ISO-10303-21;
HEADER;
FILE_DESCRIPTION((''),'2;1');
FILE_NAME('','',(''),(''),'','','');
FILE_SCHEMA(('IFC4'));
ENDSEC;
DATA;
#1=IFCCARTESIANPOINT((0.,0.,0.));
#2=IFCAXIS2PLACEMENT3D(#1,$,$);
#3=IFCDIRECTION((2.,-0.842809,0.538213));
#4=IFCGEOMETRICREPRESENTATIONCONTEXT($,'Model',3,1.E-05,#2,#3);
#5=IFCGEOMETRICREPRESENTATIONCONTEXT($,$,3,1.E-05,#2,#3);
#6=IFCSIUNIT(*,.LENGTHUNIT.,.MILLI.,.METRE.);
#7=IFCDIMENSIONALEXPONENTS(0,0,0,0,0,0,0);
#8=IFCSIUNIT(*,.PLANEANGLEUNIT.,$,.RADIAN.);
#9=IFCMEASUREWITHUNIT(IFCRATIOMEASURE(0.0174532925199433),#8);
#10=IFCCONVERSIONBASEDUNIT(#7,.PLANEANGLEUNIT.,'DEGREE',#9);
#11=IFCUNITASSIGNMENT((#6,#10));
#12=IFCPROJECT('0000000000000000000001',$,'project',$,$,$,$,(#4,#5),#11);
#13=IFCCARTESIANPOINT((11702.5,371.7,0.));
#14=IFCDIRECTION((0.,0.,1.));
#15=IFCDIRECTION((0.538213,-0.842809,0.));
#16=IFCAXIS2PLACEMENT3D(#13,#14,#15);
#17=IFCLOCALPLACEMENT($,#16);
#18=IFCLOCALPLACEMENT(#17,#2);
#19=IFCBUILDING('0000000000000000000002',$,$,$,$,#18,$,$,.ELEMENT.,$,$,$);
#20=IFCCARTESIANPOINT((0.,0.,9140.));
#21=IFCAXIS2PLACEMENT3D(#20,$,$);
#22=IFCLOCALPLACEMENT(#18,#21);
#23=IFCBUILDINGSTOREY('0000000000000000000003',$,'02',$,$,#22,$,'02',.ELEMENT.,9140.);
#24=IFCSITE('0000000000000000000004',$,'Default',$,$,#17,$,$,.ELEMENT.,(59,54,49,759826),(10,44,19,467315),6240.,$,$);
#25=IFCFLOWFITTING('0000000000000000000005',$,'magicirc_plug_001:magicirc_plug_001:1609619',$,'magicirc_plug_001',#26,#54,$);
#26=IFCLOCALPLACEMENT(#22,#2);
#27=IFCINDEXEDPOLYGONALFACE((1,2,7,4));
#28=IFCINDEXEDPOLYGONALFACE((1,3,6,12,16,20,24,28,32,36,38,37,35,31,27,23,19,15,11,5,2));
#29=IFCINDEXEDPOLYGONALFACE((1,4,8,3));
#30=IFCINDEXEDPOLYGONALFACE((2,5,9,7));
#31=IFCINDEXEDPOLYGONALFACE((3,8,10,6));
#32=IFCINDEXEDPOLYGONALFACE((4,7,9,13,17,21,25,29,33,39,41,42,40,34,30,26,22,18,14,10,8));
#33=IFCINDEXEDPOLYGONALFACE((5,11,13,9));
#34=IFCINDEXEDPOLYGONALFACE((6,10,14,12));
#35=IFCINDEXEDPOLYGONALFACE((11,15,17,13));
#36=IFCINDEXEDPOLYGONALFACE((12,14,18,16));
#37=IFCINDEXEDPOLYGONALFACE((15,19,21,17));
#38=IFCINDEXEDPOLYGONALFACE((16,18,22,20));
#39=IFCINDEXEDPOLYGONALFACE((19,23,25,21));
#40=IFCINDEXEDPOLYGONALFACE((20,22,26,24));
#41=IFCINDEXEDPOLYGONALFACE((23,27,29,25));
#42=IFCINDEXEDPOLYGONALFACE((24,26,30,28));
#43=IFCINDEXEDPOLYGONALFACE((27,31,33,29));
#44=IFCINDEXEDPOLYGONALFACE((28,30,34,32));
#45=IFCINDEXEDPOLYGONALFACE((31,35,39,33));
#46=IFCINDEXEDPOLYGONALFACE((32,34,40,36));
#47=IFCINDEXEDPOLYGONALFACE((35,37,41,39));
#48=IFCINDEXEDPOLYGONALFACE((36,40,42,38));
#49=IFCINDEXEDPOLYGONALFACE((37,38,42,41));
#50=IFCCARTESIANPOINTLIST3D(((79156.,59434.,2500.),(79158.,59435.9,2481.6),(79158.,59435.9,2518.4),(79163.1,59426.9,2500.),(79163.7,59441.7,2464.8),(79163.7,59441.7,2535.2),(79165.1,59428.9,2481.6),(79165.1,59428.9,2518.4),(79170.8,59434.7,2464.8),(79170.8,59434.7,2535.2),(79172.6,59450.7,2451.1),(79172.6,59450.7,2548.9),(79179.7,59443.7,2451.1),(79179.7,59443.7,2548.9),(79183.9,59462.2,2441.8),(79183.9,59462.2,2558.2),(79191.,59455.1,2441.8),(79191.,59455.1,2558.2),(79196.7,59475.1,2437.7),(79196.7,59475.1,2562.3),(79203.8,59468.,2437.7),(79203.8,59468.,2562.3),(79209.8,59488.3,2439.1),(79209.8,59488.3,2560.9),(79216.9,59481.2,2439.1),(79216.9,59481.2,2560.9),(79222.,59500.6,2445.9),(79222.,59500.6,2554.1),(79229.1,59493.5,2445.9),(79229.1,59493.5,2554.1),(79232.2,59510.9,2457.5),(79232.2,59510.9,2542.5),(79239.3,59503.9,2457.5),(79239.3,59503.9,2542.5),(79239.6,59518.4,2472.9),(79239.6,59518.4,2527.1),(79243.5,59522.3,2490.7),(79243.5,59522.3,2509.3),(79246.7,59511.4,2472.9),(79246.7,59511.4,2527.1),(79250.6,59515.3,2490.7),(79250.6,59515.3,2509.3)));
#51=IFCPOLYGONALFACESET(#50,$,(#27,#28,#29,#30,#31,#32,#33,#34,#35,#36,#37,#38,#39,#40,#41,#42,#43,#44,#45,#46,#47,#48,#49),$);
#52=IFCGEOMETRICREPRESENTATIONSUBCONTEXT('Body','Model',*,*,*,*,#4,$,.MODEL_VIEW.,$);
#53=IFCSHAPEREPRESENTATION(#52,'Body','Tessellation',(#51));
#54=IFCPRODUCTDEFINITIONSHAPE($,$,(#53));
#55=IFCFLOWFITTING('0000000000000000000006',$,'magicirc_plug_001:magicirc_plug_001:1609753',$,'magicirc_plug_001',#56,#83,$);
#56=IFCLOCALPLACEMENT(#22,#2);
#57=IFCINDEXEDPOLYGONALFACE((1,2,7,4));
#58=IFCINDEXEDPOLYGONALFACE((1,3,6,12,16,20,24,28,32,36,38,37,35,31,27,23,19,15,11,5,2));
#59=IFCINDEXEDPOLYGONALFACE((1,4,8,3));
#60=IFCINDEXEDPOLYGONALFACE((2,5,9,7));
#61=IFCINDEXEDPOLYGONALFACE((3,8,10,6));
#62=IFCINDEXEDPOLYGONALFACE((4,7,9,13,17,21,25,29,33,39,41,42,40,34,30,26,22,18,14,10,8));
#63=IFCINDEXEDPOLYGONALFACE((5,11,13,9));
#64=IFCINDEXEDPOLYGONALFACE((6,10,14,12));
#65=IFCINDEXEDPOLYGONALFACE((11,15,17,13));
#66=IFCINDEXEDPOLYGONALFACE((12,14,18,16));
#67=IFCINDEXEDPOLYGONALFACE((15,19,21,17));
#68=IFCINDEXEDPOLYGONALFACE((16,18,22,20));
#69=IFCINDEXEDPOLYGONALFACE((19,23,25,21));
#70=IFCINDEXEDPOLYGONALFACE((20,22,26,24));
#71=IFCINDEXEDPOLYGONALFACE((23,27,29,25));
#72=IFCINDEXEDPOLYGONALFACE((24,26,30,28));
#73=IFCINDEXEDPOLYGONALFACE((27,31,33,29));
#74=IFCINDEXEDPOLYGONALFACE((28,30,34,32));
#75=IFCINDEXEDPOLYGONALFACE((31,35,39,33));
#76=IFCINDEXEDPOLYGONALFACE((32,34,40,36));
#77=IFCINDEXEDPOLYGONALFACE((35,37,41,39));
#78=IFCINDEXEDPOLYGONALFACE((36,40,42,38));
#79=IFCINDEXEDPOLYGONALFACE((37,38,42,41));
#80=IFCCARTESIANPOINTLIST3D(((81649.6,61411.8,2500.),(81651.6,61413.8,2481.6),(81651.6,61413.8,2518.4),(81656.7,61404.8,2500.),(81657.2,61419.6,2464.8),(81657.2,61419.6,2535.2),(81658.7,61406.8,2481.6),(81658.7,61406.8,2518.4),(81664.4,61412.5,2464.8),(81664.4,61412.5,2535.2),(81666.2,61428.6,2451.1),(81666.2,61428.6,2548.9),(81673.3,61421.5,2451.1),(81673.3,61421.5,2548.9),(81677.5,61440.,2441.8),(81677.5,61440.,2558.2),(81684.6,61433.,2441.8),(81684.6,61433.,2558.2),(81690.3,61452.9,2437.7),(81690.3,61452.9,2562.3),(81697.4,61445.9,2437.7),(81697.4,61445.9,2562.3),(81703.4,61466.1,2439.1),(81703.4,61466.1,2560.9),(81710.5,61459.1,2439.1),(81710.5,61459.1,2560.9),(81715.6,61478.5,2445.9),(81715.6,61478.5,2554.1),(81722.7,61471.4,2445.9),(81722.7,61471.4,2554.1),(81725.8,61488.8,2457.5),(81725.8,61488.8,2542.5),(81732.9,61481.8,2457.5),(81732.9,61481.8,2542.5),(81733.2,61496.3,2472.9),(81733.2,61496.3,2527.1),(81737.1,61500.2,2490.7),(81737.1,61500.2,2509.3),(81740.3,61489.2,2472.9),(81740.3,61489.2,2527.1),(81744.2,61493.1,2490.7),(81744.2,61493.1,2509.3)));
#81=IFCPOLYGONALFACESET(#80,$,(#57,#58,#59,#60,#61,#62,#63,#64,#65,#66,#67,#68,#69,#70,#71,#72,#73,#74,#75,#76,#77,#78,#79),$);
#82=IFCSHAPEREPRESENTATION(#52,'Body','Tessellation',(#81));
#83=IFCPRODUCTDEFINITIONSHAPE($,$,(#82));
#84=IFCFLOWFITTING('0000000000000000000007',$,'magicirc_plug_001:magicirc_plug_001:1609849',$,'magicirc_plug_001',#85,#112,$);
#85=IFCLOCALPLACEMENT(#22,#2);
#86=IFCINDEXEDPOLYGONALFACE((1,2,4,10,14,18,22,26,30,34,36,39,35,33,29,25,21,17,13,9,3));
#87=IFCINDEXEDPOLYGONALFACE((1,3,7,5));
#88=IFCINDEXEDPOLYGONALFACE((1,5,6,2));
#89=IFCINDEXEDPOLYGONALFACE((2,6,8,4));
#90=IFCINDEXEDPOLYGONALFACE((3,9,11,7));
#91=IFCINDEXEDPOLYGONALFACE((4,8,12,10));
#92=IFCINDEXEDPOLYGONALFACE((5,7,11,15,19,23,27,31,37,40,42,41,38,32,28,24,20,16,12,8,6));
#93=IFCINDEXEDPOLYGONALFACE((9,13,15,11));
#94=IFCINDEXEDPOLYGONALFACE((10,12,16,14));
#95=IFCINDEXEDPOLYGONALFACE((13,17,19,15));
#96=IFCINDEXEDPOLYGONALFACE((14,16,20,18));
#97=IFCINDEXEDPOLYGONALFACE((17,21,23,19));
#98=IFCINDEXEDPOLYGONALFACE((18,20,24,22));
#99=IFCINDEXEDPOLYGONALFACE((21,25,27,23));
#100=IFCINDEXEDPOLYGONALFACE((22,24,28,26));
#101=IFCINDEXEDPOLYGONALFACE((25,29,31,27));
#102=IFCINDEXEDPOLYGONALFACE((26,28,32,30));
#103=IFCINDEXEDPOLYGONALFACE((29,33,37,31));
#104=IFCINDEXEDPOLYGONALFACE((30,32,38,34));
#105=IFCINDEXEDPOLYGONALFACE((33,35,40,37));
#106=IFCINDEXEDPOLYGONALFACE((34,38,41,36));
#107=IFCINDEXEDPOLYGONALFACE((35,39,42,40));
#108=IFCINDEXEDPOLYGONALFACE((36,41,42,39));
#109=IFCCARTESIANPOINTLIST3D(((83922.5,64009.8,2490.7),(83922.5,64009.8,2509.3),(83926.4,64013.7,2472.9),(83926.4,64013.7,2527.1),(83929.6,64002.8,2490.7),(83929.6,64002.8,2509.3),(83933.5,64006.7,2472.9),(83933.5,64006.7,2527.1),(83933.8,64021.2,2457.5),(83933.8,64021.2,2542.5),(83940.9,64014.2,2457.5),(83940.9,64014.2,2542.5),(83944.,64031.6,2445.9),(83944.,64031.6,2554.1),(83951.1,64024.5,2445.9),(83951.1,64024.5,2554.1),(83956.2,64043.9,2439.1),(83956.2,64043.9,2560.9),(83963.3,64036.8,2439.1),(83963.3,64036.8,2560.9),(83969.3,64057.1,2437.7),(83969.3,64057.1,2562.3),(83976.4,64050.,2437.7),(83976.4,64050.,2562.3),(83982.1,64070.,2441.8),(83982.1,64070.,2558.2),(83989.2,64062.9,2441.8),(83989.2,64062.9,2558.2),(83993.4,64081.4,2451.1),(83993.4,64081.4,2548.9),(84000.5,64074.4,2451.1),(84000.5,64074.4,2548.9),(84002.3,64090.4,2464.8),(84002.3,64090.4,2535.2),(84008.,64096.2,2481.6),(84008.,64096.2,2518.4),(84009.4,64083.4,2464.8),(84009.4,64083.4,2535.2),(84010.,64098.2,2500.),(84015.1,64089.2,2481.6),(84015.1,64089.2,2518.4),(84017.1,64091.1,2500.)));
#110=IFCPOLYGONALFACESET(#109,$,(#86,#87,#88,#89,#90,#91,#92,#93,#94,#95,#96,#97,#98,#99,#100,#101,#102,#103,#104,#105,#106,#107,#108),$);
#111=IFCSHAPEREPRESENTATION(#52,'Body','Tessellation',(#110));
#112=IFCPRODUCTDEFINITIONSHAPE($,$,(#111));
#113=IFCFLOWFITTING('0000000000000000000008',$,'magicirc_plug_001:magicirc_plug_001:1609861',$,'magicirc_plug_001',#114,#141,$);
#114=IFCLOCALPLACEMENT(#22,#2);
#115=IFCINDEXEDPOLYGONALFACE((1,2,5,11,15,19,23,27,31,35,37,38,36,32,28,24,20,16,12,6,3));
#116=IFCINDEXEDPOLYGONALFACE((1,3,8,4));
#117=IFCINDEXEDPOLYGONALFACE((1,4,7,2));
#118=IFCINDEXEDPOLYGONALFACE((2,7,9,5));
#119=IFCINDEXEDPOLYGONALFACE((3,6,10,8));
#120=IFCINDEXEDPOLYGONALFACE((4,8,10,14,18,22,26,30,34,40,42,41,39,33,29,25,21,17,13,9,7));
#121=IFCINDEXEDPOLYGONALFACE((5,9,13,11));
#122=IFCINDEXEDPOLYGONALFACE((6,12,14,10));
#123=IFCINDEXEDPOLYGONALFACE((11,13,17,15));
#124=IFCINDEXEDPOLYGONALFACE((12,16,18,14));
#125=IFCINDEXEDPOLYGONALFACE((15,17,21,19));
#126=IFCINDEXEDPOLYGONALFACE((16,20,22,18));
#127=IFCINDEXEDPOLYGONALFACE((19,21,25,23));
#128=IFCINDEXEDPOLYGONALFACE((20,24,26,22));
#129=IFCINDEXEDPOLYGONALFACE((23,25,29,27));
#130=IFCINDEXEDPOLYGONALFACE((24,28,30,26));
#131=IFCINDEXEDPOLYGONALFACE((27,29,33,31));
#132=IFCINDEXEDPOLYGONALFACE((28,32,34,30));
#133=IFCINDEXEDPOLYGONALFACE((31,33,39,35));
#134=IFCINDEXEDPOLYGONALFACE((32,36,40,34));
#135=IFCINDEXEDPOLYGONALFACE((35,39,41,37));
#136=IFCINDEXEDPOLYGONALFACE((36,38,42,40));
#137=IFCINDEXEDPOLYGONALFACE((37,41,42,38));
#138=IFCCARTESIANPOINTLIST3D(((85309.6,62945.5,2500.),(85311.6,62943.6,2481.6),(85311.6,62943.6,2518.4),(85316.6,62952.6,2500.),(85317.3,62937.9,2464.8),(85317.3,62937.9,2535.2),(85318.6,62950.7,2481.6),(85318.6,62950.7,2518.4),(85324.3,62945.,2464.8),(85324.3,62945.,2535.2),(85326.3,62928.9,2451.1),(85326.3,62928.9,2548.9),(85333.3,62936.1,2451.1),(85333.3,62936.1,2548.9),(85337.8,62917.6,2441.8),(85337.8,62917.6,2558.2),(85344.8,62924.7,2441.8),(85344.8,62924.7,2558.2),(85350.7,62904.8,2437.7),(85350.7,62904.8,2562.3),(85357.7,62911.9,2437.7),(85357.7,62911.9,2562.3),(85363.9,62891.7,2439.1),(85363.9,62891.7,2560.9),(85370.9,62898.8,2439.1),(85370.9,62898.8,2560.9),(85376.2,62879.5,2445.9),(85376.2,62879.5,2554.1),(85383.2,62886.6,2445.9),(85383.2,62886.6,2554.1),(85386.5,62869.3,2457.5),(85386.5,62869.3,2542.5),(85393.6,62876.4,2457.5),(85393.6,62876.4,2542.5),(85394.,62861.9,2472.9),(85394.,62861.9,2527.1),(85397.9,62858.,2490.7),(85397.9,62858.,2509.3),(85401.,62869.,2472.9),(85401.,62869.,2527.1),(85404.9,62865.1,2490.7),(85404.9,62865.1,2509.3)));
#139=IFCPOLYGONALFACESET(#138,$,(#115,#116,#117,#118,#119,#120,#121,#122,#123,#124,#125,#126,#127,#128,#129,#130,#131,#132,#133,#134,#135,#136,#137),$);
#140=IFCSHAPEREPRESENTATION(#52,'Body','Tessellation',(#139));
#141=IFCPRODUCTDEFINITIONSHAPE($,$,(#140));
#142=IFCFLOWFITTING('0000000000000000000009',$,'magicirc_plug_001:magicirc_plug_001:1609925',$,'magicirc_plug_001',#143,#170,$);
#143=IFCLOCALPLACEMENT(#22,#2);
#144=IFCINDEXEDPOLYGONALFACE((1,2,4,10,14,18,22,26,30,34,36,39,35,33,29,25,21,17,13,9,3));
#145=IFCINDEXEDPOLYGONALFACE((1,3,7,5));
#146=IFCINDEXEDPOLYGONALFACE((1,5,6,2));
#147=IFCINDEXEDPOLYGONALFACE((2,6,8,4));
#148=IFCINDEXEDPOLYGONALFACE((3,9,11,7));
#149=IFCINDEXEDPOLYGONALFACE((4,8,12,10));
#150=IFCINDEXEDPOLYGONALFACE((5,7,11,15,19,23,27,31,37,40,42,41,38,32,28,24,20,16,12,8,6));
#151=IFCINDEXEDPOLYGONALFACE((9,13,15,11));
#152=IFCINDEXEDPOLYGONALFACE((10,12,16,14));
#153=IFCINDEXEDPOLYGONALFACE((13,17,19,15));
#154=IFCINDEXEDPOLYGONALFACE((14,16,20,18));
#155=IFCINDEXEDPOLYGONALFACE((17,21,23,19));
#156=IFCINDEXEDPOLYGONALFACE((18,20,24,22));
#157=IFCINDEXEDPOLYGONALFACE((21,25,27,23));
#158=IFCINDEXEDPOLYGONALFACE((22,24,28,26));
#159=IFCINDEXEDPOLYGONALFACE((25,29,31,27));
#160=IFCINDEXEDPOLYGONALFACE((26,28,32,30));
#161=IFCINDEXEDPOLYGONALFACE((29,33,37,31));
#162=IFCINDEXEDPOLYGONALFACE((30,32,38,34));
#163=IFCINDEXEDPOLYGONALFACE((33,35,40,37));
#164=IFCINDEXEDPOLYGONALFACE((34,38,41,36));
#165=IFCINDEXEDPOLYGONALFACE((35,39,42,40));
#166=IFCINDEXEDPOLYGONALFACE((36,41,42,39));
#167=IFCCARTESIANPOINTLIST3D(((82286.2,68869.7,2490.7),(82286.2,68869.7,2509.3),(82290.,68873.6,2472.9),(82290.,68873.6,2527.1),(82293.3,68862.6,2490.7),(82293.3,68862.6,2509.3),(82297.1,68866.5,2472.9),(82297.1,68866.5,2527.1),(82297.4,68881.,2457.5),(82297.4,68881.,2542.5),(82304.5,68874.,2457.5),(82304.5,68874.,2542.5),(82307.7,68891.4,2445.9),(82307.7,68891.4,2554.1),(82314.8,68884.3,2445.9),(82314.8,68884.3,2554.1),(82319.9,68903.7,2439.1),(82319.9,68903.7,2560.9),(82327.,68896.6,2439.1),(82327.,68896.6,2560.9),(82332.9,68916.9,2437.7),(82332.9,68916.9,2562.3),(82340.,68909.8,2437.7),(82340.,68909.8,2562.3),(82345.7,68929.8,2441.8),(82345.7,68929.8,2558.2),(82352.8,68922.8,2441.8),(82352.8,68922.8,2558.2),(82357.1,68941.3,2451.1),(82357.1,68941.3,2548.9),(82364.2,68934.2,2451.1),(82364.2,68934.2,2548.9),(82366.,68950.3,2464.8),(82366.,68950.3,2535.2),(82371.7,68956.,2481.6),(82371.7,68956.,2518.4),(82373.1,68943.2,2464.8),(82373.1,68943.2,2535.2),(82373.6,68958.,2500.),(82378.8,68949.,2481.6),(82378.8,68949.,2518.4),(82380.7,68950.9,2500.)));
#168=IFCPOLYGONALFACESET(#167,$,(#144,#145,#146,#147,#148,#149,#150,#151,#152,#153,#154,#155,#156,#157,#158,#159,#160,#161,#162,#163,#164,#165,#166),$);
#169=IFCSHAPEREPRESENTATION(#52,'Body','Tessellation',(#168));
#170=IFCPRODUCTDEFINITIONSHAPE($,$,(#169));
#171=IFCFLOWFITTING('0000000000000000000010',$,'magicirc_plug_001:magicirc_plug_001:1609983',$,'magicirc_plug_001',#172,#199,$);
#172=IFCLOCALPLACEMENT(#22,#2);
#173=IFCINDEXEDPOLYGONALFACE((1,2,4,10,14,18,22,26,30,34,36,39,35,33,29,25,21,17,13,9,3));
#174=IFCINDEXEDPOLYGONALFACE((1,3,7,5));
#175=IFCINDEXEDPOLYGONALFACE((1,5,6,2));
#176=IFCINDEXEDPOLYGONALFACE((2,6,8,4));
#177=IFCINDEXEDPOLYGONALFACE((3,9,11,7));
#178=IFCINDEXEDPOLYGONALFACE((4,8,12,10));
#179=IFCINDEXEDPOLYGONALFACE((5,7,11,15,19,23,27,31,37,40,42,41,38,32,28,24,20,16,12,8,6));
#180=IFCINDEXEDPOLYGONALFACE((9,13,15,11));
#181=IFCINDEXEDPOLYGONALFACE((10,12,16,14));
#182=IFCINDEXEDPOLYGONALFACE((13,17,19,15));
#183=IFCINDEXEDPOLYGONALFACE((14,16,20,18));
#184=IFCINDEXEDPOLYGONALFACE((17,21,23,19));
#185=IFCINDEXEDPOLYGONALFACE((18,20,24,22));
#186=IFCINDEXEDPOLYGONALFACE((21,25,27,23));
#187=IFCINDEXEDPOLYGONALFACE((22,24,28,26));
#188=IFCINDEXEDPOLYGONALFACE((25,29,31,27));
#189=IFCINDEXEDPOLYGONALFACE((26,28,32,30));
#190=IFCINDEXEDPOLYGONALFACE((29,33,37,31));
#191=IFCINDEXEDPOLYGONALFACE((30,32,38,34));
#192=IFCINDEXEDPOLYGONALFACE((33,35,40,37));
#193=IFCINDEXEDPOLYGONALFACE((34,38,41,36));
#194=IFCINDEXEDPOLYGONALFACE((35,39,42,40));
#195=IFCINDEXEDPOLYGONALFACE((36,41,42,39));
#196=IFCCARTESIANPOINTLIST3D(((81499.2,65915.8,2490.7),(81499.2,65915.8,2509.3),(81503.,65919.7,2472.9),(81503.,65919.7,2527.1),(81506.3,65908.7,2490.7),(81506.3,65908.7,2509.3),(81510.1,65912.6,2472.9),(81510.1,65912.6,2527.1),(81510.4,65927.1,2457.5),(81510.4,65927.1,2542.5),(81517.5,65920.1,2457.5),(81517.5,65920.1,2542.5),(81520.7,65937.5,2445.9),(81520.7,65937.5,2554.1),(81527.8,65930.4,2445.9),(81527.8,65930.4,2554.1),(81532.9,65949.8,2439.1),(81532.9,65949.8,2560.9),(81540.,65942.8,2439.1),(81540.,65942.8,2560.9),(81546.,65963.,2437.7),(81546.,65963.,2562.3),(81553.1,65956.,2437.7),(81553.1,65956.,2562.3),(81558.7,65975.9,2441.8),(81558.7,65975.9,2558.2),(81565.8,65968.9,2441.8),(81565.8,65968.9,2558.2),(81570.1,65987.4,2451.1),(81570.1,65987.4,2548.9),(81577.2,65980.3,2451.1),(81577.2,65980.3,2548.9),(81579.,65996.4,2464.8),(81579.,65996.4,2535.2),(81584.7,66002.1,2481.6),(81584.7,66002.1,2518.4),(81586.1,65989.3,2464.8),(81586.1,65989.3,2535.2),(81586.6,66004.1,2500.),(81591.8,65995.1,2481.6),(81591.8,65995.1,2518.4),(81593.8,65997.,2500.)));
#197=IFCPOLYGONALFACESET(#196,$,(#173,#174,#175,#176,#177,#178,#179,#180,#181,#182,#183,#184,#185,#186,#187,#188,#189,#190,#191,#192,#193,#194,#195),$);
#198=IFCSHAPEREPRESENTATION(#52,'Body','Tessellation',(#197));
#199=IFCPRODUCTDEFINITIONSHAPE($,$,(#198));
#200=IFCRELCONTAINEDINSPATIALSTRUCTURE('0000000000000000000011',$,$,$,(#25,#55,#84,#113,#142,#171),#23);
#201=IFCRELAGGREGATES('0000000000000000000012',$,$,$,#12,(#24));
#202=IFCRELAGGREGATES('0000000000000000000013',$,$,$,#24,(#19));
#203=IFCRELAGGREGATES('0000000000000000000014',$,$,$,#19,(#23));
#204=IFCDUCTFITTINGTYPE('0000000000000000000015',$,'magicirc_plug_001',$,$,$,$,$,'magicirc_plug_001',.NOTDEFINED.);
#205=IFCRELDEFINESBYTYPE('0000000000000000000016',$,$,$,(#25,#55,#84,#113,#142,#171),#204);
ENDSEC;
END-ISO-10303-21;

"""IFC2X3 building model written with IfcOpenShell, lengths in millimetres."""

from ifc_helpers import new_model, entity, si_unit, converted_unit, direction, frame, frame_2d, origin, place, context, subcontext, project, spatial, circle, extrude, source, transform, mapped, type_object, type_shapes, element, save


model = new_model("IFC2X3")

# Units and contexts
model_context = context("Model", 3, precision=1e-05, world=origin(), true_north=direction((2.0, -0.842809, 0.538213)))
context_of_model = context(None, 3, precision=1e-05, world=origin(), true_north=direction((2.0, -0.842809, 0.538213)))
body_context = subcontext(model_context, "Body", "Model", "MODEL_VIEW")
ifc_project = project(units=[si_unit("LENGTHUNIT", "METRE", prefix="MILLI"), converted_unit("PLANEANGLEUNIT", "DEGREE", entity("IfcRatioMeasure", 0.0174532925199433), si_unit("PLANEANGLEUNIT", "RADIAN"), dimensions=[0, 0, 0, 0, 0, 0, 0])], contexts=[model_context, context_of_model])

# Site, building, storey
site_placement = place(None, frame((11702.5, 371.7, 0.0), z_axis=(0.0, 0.0, 1.0), x_axis=(0.538213, -0.842809, 0.0)))
site = spatial("IfcSite", under=ifc_project, at=site_placement, Name="Default", CompositionType="ELEMENT", RefLatitude=(59, 54, 49, 759826), RefLongitude=(10, 44, 19, 467315), RefElevation=6240.0)
building_placement = place(site_placement, origin())
building = spatial("IfcBuilding", under=site, at=building_placement, CompositionType="ELEMENT")
storey_placement = place(building_placement, frame((0.0, 0.0, 9140.0)))
storey = spatial("IfcBuildingStorey", under=building, at=storey_placement, Name="02", LongName="02", CompositionType="ELEMENT", Elevation=9140.0)

# Flow fittings
duct_fitting_type_1 = type_object("IfcDuctFittingType", Name="magicirc_plug_001", ElementType="magicirc_plug_001", PredefinedType="NOTDEFINED")
shared_shape_1 = source(origin(), body_context, "Body", "SweptSolid", [
    extrude(circle(Radius=62.5, at=frame_2d((0.0, 0.0), x_axis=(1.0, 0.0))), frame((0.0, 0.0, 0.0), z_axis=(1.0, 0.0, 0.0), x_axis=(0.0, 1.0, 0.0)), (0.0, 0.0, 1.0), 10.0),
])
type_shapes(duct_fitting_type_1, [shared_shape_1])
for number, where, z_axis, x_axis, name in (
    (1, (79207.1, 59471.3, 2500.0), (0.0, 0.0, 1.0), (-0.710528, 0.703669, 0.0), "magicirc_plug_001:magicirc_plug_001:1609619"),
    (2, (81700.7, 61449.2, 2500.0), (0.0, 0.0, 1.0), (-0.710528, 0.703669, 0.0), "magicirc_plug_001:magicirc_plug_001:1609753"),
    (3, (83966.0, 64053.8, 2500.0), (0.0, 0.0, 1.0), (0.710528, -0.703669, 0.0), "magicirc_plug_001:magicirc_plug_001:1609849"),
    (4, (85354.0, 62901.5, 2500.0), (0.0, 0.0, 1.0), (0.703669, 0.710528, 0.0), "magicirc_plug_001:magicirc_plug_001:1609861"),
    (5, (82329.6, 68913.6, 2500.0), (0.0, 0.0, 1.0), (0.710528, -0.703669, 0.0), "magicirc_plug_001:magicirc_plug_001:1609925"),
    (6, (81542.7, 65959.7, 2500.0), (0.0, 0.0, 1.0), (0.710528, -0.703669, 0.0), "magicirc_plug_001:magicirc_plug_001:1609983"),
):
    element("IfcFlowFitting", number, at=place(storey_placement, frame(where, z_axis=z_axis, x_axis=x_axis)), inside=storey, type_object=duct_fitting_type_1, Name=name, ObjectType="magicirc_plug_001", context=body_context, shape_type="MappedRepresentation", body=[
        mapped(shared_shape_1, transform((0.0, 0.0, 0.0), scale=1.0)),
    ])

save(model, "model.ifc")
